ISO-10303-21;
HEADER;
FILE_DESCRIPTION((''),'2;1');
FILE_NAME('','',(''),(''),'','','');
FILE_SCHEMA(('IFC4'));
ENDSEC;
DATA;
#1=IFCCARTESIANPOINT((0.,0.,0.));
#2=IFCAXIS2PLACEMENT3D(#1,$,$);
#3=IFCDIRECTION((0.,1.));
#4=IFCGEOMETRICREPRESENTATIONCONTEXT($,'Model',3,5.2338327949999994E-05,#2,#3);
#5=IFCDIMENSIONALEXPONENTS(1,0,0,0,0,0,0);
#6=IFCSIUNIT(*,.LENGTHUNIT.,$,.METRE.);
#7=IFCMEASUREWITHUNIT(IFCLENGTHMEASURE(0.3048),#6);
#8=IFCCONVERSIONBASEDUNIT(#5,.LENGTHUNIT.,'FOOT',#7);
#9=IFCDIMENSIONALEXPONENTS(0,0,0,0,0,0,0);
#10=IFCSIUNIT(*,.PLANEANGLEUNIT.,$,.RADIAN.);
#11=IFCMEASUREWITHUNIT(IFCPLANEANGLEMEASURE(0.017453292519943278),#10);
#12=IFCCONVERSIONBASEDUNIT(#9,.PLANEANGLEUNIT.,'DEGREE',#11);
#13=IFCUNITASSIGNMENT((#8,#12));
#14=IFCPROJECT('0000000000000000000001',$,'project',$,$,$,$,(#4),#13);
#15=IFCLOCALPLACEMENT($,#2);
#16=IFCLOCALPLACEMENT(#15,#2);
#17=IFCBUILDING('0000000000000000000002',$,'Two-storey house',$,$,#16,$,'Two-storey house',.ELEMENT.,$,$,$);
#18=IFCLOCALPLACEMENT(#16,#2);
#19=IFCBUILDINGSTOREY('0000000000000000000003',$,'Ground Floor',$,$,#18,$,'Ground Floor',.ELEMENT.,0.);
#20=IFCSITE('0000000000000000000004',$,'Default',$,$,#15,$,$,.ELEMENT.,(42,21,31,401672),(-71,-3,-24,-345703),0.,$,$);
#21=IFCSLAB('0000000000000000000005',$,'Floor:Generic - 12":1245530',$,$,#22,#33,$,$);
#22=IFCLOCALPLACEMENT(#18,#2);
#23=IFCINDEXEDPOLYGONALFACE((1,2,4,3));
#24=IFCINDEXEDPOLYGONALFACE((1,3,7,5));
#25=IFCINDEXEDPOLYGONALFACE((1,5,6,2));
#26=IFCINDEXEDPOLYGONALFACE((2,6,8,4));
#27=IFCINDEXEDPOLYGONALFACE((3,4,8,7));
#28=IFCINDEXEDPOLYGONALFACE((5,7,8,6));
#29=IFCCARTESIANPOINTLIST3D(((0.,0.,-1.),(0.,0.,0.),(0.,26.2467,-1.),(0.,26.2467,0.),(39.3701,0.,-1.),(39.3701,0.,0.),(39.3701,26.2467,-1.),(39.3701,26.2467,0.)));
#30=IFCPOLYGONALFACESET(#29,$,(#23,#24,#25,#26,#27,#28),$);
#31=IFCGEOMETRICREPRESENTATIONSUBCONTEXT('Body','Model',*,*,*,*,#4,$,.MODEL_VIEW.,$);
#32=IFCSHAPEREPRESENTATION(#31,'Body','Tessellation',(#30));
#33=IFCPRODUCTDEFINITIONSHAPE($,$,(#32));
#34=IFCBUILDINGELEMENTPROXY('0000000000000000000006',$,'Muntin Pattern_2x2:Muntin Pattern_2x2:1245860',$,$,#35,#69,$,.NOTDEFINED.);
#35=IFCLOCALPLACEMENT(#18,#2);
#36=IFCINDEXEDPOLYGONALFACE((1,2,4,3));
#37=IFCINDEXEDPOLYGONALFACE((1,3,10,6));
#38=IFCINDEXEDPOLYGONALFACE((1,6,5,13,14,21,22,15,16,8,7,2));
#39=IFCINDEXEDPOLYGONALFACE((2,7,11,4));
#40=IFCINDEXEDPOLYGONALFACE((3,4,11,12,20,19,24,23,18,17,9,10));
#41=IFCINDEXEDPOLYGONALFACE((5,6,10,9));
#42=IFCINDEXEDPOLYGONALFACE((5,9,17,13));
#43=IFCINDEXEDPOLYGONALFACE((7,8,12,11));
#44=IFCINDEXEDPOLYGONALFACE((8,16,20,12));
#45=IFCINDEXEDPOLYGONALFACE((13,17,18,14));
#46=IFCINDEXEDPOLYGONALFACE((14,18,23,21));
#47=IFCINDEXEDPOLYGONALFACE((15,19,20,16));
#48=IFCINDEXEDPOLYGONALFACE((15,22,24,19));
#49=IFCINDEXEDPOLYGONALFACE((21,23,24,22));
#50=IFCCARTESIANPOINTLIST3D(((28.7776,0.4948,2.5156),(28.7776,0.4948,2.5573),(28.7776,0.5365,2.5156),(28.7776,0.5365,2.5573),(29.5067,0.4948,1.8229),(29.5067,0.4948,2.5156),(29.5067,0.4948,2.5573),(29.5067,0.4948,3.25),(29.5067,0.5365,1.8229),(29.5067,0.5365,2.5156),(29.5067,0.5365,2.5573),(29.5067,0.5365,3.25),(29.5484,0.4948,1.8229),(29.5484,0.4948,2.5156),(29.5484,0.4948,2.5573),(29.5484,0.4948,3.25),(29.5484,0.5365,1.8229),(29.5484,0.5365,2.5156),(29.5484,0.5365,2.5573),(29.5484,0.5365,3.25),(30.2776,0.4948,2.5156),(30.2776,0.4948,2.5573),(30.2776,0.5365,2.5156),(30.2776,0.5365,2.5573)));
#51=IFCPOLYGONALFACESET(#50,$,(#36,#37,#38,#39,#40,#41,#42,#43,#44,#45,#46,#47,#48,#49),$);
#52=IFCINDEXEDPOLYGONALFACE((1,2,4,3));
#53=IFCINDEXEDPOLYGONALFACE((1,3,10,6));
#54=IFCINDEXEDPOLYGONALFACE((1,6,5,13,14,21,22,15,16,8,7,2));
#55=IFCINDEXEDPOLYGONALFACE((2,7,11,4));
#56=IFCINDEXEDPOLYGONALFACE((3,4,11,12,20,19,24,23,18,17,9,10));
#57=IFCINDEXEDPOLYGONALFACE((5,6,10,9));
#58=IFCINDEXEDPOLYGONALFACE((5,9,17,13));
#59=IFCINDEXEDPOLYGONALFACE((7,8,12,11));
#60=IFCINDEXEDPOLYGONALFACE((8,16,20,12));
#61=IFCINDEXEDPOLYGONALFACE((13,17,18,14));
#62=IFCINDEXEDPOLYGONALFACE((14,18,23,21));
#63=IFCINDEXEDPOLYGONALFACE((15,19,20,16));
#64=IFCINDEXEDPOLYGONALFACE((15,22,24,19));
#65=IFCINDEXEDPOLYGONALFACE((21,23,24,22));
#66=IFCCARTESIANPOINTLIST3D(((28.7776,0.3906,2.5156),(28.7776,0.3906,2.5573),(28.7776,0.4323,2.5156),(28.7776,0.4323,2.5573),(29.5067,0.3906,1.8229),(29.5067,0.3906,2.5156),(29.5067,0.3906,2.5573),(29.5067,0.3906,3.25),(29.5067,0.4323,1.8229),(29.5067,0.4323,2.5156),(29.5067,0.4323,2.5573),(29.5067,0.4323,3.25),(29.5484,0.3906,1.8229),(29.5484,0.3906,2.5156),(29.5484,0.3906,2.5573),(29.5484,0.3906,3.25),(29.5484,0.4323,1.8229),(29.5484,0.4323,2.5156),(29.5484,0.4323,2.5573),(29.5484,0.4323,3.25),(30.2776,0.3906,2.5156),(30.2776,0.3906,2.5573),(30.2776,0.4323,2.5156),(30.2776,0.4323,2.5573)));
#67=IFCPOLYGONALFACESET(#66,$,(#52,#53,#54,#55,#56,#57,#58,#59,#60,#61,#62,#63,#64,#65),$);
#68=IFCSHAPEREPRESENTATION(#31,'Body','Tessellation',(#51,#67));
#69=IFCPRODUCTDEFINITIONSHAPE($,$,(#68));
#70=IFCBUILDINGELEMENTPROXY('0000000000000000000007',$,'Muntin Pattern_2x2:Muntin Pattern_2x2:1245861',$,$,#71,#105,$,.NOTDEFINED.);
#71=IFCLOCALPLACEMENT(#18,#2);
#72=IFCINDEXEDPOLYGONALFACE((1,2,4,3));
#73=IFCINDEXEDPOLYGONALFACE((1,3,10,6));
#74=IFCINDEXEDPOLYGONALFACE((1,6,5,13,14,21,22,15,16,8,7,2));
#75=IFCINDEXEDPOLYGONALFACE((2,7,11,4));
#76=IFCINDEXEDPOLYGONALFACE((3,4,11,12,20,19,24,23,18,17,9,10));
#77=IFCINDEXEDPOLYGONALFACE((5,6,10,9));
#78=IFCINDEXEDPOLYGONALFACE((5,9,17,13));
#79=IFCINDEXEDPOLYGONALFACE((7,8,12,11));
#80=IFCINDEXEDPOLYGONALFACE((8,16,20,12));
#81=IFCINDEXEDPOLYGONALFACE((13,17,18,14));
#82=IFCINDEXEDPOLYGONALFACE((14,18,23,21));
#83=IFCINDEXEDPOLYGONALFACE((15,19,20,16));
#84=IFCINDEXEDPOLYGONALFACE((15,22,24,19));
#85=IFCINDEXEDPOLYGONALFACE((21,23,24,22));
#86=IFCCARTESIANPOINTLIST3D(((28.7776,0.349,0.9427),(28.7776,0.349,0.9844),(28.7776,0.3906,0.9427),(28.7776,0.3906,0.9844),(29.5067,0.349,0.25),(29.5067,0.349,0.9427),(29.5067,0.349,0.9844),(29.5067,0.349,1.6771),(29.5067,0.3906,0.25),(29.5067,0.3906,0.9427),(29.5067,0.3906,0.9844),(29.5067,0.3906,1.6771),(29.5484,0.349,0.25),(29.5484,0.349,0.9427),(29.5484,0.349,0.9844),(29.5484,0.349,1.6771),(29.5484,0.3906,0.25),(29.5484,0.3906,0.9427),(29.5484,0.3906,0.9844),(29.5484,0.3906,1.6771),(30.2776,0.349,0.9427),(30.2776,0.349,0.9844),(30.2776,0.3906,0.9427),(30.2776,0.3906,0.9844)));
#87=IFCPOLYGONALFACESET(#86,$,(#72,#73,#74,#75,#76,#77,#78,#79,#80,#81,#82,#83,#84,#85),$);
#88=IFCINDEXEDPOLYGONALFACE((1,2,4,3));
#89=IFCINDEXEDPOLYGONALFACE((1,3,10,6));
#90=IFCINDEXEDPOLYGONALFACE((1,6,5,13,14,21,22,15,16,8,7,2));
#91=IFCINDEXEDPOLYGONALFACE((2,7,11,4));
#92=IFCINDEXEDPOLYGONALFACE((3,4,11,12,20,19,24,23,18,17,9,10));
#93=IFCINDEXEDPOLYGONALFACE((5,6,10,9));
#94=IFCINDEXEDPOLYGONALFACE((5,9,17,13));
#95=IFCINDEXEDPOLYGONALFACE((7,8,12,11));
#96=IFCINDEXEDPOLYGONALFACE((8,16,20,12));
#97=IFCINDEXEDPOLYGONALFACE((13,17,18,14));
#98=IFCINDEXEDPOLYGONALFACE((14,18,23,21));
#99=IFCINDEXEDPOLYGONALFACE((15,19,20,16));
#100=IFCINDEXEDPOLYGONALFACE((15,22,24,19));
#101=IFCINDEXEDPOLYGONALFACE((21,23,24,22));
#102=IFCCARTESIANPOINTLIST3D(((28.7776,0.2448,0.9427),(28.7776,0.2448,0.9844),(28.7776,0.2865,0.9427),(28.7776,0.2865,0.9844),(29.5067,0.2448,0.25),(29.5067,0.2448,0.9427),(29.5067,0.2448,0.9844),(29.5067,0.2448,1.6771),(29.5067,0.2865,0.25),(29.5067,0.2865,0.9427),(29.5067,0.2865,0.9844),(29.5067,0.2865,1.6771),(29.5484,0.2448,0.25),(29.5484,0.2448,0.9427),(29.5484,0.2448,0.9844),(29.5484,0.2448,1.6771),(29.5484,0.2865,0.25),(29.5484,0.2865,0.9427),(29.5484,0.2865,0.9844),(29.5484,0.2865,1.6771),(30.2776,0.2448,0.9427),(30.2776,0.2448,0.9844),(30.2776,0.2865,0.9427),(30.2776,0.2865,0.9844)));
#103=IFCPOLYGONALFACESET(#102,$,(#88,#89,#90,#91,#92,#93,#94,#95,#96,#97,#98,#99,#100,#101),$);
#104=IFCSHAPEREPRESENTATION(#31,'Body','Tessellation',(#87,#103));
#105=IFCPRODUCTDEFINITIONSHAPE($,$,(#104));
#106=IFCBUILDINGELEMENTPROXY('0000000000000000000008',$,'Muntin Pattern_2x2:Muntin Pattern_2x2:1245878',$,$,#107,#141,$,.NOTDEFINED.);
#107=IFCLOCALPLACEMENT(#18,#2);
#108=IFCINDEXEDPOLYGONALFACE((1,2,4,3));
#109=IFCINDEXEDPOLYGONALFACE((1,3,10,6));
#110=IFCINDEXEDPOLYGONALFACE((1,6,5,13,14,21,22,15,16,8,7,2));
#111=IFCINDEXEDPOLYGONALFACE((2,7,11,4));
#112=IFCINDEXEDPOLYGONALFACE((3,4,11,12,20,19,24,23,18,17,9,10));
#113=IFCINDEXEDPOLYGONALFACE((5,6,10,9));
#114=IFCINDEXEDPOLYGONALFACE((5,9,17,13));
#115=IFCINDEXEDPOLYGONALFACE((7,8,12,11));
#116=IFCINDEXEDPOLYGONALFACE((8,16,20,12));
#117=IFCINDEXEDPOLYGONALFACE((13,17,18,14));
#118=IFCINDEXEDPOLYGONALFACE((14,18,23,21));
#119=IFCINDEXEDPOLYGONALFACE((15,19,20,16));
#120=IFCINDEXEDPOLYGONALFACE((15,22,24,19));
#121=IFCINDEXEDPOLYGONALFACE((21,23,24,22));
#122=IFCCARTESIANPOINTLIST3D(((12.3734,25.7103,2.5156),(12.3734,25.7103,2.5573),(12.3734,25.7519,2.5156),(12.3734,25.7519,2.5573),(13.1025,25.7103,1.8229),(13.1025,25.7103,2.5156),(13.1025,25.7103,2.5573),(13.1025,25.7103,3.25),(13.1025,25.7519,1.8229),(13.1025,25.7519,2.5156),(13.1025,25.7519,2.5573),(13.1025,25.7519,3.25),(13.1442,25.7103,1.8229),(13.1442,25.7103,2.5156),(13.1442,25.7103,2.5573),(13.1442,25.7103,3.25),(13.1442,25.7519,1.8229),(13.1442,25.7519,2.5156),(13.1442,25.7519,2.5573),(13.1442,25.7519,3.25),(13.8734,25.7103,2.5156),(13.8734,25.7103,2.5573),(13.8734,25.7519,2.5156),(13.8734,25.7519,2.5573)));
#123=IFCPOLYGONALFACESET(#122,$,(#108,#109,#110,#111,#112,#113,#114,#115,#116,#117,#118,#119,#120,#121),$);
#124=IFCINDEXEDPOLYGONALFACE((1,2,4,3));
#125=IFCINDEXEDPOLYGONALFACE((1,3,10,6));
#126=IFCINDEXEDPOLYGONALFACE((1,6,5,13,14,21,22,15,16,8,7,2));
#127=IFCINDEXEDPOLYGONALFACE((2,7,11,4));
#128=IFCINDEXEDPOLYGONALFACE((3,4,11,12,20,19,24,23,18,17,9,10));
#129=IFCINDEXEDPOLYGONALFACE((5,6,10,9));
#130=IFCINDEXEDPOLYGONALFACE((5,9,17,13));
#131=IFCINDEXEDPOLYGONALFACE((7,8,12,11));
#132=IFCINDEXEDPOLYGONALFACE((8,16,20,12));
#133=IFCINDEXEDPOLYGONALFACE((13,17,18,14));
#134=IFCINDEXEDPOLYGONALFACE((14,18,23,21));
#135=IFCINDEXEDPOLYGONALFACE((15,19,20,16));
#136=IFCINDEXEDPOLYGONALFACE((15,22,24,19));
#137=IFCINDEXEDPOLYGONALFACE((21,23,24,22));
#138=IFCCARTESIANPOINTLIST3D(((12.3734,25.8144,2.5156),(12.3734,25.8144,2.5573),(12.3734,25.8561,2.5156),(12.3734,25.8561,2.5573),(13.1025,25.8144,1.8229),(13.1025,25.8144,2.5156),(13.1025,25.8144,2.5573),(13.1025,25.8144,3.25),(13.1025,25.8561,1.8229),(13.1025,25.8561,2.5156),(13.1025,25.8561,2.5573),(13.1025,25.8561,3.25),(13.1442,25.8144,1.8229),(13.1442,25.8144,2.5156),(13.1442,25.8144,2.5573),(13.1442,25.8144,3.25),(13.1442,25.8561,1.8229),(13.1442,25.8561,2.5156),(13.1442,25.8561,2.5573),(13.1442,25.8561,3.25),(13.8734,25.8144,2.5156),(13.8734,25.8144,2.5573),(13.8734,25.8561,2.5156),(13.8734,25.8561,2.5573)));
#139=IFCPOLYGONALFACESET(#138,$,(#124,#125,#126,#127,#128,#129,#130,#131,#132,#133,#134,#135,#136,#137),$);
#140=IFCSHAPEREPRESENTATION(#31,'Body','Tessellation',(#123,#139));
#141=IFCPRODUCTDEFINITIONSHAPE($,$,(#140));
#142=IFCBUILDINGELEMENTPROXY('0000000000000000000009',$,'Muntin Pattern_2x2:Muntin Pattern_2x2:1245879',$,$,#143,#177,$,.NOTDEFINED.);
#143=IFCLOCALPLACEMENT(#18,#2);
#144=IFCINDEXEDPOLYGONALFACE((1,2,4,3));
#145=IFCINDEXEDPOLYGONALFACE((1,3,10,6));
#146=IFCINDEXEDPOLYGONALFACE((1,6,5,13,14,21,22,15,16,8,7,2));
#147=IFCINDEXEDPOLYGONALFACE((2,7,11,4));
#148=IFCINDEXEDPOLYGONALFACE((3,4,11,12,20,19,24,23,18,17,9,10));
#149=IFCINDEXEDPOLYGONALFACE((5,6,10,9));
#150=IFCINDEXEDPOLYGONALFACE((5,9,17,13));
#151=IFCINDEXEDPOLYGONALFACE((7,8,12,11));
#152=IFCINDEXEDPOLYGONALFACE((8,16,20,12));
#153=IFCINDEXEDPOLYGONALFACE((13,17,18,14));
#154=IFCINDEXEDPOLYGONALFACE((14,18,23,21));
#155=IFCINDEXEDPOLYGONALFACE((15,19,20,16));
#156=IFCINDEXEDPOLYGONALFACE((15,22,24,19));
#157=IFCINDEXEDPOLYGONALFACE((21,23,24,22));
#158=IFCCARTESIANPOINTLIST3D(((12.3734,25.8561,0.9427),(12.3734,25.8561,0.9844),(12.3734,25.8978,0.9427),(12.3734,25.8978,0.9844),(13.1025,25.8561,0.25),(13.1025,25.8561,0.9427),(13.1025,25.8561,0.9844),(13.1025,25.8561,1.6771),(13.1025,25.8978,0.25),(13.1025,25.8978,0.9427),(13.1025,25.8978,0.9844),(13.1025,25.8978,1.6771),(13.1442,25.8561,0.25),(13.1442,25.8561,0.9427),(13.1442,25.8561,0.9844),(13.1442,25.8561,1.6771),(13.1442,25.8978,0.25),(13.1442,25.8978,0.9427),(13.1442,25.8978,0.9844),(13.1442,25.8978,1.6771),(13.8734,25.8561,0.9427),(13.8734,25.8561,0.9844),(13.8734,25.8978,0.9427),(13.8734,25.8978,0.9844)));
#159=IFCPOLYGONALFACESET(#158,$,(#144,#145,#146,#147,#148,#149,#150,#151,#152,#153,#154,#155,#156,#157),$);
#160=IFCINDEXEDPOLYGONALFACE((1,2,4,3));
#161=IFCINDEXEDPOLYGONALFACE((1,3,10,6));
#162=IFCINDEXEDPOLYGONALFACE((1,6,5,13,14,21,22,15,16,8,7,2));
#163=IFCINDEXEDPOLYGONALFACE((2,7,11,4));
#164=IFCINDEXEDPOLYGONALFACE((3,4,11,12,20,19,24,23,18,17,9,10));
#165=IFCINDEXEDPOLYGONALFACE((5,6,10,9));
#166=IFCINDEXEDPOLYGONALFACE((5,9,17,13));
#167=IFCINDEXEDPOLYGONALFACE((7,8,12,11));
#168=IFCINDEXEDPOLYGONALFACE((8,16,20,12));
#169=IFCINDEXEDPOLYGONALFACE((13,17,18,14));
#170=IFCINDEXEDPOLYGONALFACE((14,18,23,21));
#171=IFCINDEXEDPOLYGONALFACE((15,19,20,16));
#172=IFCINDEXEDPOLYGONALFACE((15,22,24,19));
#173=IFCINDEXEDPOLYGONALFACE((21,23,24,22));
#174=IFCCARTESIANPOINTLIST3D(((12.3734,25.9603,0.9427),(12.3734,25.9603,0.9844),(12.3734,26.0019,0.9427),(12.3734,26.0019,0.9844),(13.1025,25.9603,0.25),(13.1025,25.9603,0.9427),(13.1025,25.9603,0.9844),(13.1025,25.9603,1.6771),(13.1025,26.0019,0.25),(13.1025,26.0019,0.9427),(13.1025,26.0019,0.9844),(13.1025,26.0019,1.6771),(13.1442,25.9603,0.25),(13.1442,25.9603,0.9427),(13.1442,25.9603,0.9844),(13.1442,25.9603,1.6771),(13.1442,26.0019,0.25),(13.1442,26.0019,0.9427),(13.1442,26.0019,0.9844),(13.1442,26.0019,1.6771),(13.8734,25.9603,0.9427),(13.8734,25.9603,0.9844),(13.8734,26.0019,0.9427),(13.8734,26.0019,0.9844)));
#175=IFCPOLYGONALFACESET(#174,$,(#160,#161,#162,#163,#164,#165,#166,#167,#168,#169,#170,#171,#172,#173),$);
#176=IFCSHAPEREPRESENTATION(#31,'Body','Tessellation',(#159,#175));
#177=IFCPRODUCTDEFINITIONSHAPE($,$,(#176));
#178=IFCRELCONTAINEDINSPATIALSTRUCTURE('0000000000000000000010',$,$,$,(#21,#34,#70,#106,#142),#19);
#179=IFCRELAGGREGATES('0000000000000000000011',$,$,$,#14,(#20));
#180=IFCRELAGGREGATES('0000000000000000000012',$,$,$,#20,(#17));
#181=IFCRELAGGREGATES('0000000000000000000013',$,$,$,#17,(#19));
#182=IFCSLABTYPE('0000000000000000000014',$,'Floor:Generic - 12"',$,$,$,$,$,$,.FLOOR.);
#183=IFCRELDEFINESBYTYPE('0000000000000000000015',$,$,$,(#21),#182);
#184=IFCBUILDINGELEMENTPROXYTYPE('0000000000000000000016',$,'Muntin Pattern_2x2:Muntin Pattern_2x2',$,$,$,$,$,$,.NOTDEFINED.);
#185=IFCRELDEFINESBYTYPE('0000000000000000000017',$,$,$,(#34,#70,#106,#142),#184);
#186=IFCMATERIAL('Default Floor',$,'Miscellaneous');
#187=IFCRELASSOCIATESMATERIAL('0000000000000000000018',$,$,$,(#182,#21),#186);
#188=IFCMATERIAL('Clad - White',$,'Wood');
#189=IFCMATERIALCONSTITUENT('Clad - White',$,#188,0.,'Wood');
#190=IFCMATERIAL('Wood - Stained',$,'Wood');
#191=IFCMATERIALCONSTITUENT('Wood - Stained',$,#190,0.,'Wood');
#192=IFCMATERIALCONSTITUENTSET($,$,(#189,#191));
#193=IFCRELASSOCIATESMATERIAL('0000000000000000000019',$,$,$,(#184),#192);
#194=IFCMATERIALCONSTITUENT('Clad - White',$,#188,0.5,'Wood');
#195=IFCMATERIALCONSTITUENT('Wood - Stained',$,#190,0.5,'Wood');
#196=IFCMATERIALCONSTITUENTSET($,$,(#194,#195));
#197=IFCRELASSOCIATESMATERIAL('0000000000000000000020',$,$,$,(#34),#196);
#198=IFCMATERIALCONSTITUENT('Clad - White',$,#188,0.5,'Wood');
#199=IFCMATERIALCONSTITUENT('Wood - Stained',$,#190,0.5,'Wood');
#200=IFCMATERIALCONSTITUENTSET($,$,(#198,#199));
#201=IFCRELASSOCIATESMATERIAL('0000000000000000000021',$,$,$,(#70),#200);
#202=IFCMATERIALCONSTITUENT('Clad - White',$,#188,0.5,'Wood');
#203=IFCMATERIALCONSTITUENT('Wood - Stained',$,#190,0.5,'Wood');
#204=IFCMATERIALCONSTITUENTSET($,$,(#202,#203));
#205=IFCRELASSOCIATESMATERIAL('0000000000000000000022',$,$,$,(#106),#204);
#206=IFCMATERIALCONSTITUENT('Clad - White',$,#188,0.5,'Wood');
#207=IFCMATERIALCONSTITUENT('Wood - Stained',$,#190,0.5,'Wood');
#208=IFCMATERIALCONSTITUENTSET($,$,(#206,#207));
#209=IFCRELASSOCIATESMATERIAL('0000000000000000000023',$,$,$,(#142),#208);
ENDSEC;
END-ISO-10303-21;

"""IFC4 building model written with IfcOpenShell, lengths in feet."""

from ifc_helpers import new_model, entity, si_unit, converted_unit, direction, frame, origin, place, context, subcontext, project, spatial, indexed_curve, outline, extrude, source, transform, mapped, material, constituent, constituent_set, type_object, type_shapes, element, save


model = new_model("IFC4")

# Units and contexts
model_context = context("Model", 3, precision=5.2338327949999994e-05, world=origin(), true_north=direction((0.0, 1.0)))
body_context = subcontext(model_context, "Body", "Model", "MODEL_VIEW")
ifc_project = project(units=[converted_unit("LENGTHUNIT", "FOOT", entity("IfcLengthMeasure", 0.3048), si_unit("LENGTHUNIT", "METRE"), dimensions=[1, 0, 0, 0, 0, 0, 0]), converted_unit("PLANEANGLEUNIT", "DEGREE", entity("IfcPlaneAngleMeasure", 0.017453292519943278), si_unit("PLANEANGLEUNIT", "RADIAN"), dimensions=[0, 0, 0, 0, 0, 0, 0])], contexts=[model_context])

# Site, building, storey
site_placement = place(None, origin())
building_placement = place(site_placement, origin())
storey_placement = place(building_placement, origin())
site = spatial("IfcSite", under=ifc_project, at=site_placement, Name="Default", CompositionType="ELEMENT", RefLatitude=(42, 21, 31, 401672), RefLongitude=(-71, -3, -24, -345703), RefElevation=0.0)
building = spatial("IfcBuilding", under=site, at=building_placement, Name="Two-storey house", LongName="Two-storey house", CompositionType="ELEMENT")
storey = spatial("IfcBuildingStorey", under=building, at=storey_placement, Name="Ground Floor", LongName="Ground Floor", CompositionType="ELEMENT", Elevation=0.0)

# Slab
ifc_material_1 = material(Name="Default Floor", Category="Miscellaneous")
slab_type = type_object("IfcSlabType", Name="Floor:Generic - 12\"", PredefinedType="FLOOR", material=ifc_material_1)
slab_placement = place(storey_placement, origin())
element("IfcSlab", 1, at=slab_placement, inside=storey, type_object=slab_type, material=ifc_material_1, Name="Floor:Generic - 12\":1245530", context=body_context, shape_type="SweptSolid", body=[
    extrude(outline(indexed_curve([(-13.1234, -19.685), (13.1234, -19.685), (13.1234, 19.685), (-13.1234, 19.685), (-13.1234, -19.685)], self_intersect=False)), frame((19.685, 13.1234, 0.0), z_axis=(0.0, 0.0, -1.0), x_axis=(0.0, 1.0, 0.0)), (0.0, 0.0, 1.0), 1.0),
])

# Shared definitions
ifc_material_2 = material(Name="Wood - Stained", Category="Wood")

# Building element proxies
ifc_material_3 = material(Name="Clad - White", Category="Wood")
ifc_constituent_1 = constituent(ifc_material_3, Name="Clad - White", Category="Wood", fraction=0.5)
ifc_constituent_2 = constituent(ifc_material_2, Name="Wood - Stained", Category="Wood", fraction=0.5)
ifc_constituent_set_1 = constituent_set(constituents=[ifc_constituent_1, ifc_constituent_2])
ifc_constituent_3 = constituent(ifc_material_3, Name="Clad - White", Category="Wood", fraction=0.0)
ifc_constituent_4 = constituent(ifc_material_2, Name="Wood - Stained", Category="Wood", fraction=0.0)
ifc_constituent_set_2 = constituent_set(constituents=[ifc_constituent_3, ifc_constituent_4])
building_element_proxy_type_1 = type_object("IfcBuildingElementProxyType", Name="Muntin Pattern_2x2:Muntin Pattern_2x2", PredefinedType="NOTDEFINED", material=ifc_constituent_set_2)
shared_shape_1 = source(origin(), body_context, "Body", "SweptSolid", [
    extrude(outline(indexed_curve([(0.0208, -0.0208), (0.7135, -0.0208), (0.7135, 0.0208), (0.0208, 0.0208), (0.0208, 0.75), (-0.0208, 0.75), (-0.0208, 0.0208), (-0.7135, 0.0208), (-0.7135, -0.0208), (-0.0208, -0.0208), (-0.0208, -0.75), (0.0208, -0.75), (0.0208, -0.0208)], self_intersect=False)), frame((0.0, 0.0312, 0.7135), z_axis=(0.0, 1.0, 0.0), x_axis=(0.0, 0.0, 1.0)), (0.0, 0.0, 1.0), 0.0417),
    extrude(outline(indexed_curve([(0.0208, -0.0208), (0.7135, -0.0208), (0.7135, 0.0208), (0.0208, 0.0208), (0.0208, 0.75), (-0.0208, 0.75), (-0.0208, 0.0208), (-0.7135, 0.0208), (-0.7135, -0.0208), (-0.0208, -0.0208), (-0.0208, -0.75), (0.0208, -0.75), (0.0208, -0.0208)], self_intersect=False)), frame((0.0, -0.0729, 0.7135), z_axis=(0.0, 1.0, 0.0), x_axis=(0.0, 0.0, 1.0)), (0.0, 0.0, 1.0), 0.0417),
])
type_shapes(building_element_proxy_type_1, [shared_shape_1])
proxy_1_placement = place(storey_placement, frame((29.5276, 0.4635, 1.8229)))
element("IfcBuildingElementProxy", 2, at=proxy_1_placement, inside=storey, type_object=building_element_proxy_type_1, material=ifc_constituent_set_1, Name="Muntin Pattern_2x2:Muntin Pattern_2x2:1245860", PredefinedType="NOTDEFINED", context=body_context, shape_type="MappedRepresentation", body=[
    mapped(shared_shape_1, transform((0.0, 0.0, 0.0), scale=1.0)),
])
ifc_constituent_5 = constituent(ifc_material_3, Name="Clad - White", Category="Wood", fraction=0.5)
ifc_constituent_6 = constituent(ifc_material_2, Name="Wood - Stained", Category="Wood", fraction=0.5)
ifc_constituent_set_3 = constituent_set(constituents=[ifc_constituent_5, ifc_constituent_6])
proxy_2_placement = place(storey_placement, frame((29.5276, 0.3177, 0.25)))
element("IfcBuildingElementProxy", 3, at=proxy_2_placement, inside=storey, type_object=building_element_proxy_type_1, material=ifc_constituent_set_3, Name="Muntin Pattern_2x2:Muntin Pattern_2x2:1245861", PredefinedType="NOTDEFINED", context=body_context, shape_type="MappedRepresentation", body=[
    mapped(shared_shape_1, transform((0.0, 0.0, 0.0), scale=1.0)),
])
ifc_constituent_7 = constituent(ifc_material_3, Name="Clad - White", Category="Wood", fraction=0.5)
ifc_constituent_8 = constituent(ifc_material_2, Name="Wood - Stained", Category="Wood", fraction=0.5)
ifc_constituent_set_4 = constituent_set(constituents=[ifc_constituent_7, ifc_constituent_8])
proxy_3_placement = place(storey_placement, frame((13.1234, 25.7832, 1.8229), z_axis=(0.0, 0.0, 1.0), x_axis=(-1.0, 0.0, 0.0)))
element("IfcBuildingElementProxy", 4, at=proxy_3_placement, inside=storey, type_object=building_element_proxy_type_1, material=ifc_constituent_set_4, Name="Muntin Pattern_2x2:Muntin Pattern_2x2:1245878", PredefinedType="NOTDEFINED", context=body_context, shape_type="MappedRepresentation", body=[
    mapped(shared_shape_1, transform((0.0, 0.0, 0.0), scale=1.0)),
])
ifc_constituent_9 = constituent(ifc_material_3, Name="Clad - White", Category="Wood", fraction=0.5)
ifc_constituent_10 = constituent(ifc_material_2, Name="Wood - Stained", Category="Wood", fraction=0.5)
ifc_constituent_set_5 = constituent_set(constituents=[ifc_constituent_9, ifc_constituent_10])
proxy_4_placement = place(storey_placement, frame((13.1234, 25.929, 0.25), z_axis=(0.0, 0.0, 1.0), x_axis=(-1.0, 0.0, 0.0)))
element("IfcBuildingElementProxy", 5, at=proxy_4_placement, inside=storey, type_object=building_element_proxy_type_1, material=ifc_constituent_set_5, Name="Muntin Pattern_2x2:Muntin Pattern_2x2:1245879", PredefinedType="NOTDEFINED", context=body_context, shape_type="MappedRepresentation", body=[
    mapped(shared_shape_1, transform((0.0, 0.0, 0.0), scale=1.0)),
])

save(model, "model.ifc")
